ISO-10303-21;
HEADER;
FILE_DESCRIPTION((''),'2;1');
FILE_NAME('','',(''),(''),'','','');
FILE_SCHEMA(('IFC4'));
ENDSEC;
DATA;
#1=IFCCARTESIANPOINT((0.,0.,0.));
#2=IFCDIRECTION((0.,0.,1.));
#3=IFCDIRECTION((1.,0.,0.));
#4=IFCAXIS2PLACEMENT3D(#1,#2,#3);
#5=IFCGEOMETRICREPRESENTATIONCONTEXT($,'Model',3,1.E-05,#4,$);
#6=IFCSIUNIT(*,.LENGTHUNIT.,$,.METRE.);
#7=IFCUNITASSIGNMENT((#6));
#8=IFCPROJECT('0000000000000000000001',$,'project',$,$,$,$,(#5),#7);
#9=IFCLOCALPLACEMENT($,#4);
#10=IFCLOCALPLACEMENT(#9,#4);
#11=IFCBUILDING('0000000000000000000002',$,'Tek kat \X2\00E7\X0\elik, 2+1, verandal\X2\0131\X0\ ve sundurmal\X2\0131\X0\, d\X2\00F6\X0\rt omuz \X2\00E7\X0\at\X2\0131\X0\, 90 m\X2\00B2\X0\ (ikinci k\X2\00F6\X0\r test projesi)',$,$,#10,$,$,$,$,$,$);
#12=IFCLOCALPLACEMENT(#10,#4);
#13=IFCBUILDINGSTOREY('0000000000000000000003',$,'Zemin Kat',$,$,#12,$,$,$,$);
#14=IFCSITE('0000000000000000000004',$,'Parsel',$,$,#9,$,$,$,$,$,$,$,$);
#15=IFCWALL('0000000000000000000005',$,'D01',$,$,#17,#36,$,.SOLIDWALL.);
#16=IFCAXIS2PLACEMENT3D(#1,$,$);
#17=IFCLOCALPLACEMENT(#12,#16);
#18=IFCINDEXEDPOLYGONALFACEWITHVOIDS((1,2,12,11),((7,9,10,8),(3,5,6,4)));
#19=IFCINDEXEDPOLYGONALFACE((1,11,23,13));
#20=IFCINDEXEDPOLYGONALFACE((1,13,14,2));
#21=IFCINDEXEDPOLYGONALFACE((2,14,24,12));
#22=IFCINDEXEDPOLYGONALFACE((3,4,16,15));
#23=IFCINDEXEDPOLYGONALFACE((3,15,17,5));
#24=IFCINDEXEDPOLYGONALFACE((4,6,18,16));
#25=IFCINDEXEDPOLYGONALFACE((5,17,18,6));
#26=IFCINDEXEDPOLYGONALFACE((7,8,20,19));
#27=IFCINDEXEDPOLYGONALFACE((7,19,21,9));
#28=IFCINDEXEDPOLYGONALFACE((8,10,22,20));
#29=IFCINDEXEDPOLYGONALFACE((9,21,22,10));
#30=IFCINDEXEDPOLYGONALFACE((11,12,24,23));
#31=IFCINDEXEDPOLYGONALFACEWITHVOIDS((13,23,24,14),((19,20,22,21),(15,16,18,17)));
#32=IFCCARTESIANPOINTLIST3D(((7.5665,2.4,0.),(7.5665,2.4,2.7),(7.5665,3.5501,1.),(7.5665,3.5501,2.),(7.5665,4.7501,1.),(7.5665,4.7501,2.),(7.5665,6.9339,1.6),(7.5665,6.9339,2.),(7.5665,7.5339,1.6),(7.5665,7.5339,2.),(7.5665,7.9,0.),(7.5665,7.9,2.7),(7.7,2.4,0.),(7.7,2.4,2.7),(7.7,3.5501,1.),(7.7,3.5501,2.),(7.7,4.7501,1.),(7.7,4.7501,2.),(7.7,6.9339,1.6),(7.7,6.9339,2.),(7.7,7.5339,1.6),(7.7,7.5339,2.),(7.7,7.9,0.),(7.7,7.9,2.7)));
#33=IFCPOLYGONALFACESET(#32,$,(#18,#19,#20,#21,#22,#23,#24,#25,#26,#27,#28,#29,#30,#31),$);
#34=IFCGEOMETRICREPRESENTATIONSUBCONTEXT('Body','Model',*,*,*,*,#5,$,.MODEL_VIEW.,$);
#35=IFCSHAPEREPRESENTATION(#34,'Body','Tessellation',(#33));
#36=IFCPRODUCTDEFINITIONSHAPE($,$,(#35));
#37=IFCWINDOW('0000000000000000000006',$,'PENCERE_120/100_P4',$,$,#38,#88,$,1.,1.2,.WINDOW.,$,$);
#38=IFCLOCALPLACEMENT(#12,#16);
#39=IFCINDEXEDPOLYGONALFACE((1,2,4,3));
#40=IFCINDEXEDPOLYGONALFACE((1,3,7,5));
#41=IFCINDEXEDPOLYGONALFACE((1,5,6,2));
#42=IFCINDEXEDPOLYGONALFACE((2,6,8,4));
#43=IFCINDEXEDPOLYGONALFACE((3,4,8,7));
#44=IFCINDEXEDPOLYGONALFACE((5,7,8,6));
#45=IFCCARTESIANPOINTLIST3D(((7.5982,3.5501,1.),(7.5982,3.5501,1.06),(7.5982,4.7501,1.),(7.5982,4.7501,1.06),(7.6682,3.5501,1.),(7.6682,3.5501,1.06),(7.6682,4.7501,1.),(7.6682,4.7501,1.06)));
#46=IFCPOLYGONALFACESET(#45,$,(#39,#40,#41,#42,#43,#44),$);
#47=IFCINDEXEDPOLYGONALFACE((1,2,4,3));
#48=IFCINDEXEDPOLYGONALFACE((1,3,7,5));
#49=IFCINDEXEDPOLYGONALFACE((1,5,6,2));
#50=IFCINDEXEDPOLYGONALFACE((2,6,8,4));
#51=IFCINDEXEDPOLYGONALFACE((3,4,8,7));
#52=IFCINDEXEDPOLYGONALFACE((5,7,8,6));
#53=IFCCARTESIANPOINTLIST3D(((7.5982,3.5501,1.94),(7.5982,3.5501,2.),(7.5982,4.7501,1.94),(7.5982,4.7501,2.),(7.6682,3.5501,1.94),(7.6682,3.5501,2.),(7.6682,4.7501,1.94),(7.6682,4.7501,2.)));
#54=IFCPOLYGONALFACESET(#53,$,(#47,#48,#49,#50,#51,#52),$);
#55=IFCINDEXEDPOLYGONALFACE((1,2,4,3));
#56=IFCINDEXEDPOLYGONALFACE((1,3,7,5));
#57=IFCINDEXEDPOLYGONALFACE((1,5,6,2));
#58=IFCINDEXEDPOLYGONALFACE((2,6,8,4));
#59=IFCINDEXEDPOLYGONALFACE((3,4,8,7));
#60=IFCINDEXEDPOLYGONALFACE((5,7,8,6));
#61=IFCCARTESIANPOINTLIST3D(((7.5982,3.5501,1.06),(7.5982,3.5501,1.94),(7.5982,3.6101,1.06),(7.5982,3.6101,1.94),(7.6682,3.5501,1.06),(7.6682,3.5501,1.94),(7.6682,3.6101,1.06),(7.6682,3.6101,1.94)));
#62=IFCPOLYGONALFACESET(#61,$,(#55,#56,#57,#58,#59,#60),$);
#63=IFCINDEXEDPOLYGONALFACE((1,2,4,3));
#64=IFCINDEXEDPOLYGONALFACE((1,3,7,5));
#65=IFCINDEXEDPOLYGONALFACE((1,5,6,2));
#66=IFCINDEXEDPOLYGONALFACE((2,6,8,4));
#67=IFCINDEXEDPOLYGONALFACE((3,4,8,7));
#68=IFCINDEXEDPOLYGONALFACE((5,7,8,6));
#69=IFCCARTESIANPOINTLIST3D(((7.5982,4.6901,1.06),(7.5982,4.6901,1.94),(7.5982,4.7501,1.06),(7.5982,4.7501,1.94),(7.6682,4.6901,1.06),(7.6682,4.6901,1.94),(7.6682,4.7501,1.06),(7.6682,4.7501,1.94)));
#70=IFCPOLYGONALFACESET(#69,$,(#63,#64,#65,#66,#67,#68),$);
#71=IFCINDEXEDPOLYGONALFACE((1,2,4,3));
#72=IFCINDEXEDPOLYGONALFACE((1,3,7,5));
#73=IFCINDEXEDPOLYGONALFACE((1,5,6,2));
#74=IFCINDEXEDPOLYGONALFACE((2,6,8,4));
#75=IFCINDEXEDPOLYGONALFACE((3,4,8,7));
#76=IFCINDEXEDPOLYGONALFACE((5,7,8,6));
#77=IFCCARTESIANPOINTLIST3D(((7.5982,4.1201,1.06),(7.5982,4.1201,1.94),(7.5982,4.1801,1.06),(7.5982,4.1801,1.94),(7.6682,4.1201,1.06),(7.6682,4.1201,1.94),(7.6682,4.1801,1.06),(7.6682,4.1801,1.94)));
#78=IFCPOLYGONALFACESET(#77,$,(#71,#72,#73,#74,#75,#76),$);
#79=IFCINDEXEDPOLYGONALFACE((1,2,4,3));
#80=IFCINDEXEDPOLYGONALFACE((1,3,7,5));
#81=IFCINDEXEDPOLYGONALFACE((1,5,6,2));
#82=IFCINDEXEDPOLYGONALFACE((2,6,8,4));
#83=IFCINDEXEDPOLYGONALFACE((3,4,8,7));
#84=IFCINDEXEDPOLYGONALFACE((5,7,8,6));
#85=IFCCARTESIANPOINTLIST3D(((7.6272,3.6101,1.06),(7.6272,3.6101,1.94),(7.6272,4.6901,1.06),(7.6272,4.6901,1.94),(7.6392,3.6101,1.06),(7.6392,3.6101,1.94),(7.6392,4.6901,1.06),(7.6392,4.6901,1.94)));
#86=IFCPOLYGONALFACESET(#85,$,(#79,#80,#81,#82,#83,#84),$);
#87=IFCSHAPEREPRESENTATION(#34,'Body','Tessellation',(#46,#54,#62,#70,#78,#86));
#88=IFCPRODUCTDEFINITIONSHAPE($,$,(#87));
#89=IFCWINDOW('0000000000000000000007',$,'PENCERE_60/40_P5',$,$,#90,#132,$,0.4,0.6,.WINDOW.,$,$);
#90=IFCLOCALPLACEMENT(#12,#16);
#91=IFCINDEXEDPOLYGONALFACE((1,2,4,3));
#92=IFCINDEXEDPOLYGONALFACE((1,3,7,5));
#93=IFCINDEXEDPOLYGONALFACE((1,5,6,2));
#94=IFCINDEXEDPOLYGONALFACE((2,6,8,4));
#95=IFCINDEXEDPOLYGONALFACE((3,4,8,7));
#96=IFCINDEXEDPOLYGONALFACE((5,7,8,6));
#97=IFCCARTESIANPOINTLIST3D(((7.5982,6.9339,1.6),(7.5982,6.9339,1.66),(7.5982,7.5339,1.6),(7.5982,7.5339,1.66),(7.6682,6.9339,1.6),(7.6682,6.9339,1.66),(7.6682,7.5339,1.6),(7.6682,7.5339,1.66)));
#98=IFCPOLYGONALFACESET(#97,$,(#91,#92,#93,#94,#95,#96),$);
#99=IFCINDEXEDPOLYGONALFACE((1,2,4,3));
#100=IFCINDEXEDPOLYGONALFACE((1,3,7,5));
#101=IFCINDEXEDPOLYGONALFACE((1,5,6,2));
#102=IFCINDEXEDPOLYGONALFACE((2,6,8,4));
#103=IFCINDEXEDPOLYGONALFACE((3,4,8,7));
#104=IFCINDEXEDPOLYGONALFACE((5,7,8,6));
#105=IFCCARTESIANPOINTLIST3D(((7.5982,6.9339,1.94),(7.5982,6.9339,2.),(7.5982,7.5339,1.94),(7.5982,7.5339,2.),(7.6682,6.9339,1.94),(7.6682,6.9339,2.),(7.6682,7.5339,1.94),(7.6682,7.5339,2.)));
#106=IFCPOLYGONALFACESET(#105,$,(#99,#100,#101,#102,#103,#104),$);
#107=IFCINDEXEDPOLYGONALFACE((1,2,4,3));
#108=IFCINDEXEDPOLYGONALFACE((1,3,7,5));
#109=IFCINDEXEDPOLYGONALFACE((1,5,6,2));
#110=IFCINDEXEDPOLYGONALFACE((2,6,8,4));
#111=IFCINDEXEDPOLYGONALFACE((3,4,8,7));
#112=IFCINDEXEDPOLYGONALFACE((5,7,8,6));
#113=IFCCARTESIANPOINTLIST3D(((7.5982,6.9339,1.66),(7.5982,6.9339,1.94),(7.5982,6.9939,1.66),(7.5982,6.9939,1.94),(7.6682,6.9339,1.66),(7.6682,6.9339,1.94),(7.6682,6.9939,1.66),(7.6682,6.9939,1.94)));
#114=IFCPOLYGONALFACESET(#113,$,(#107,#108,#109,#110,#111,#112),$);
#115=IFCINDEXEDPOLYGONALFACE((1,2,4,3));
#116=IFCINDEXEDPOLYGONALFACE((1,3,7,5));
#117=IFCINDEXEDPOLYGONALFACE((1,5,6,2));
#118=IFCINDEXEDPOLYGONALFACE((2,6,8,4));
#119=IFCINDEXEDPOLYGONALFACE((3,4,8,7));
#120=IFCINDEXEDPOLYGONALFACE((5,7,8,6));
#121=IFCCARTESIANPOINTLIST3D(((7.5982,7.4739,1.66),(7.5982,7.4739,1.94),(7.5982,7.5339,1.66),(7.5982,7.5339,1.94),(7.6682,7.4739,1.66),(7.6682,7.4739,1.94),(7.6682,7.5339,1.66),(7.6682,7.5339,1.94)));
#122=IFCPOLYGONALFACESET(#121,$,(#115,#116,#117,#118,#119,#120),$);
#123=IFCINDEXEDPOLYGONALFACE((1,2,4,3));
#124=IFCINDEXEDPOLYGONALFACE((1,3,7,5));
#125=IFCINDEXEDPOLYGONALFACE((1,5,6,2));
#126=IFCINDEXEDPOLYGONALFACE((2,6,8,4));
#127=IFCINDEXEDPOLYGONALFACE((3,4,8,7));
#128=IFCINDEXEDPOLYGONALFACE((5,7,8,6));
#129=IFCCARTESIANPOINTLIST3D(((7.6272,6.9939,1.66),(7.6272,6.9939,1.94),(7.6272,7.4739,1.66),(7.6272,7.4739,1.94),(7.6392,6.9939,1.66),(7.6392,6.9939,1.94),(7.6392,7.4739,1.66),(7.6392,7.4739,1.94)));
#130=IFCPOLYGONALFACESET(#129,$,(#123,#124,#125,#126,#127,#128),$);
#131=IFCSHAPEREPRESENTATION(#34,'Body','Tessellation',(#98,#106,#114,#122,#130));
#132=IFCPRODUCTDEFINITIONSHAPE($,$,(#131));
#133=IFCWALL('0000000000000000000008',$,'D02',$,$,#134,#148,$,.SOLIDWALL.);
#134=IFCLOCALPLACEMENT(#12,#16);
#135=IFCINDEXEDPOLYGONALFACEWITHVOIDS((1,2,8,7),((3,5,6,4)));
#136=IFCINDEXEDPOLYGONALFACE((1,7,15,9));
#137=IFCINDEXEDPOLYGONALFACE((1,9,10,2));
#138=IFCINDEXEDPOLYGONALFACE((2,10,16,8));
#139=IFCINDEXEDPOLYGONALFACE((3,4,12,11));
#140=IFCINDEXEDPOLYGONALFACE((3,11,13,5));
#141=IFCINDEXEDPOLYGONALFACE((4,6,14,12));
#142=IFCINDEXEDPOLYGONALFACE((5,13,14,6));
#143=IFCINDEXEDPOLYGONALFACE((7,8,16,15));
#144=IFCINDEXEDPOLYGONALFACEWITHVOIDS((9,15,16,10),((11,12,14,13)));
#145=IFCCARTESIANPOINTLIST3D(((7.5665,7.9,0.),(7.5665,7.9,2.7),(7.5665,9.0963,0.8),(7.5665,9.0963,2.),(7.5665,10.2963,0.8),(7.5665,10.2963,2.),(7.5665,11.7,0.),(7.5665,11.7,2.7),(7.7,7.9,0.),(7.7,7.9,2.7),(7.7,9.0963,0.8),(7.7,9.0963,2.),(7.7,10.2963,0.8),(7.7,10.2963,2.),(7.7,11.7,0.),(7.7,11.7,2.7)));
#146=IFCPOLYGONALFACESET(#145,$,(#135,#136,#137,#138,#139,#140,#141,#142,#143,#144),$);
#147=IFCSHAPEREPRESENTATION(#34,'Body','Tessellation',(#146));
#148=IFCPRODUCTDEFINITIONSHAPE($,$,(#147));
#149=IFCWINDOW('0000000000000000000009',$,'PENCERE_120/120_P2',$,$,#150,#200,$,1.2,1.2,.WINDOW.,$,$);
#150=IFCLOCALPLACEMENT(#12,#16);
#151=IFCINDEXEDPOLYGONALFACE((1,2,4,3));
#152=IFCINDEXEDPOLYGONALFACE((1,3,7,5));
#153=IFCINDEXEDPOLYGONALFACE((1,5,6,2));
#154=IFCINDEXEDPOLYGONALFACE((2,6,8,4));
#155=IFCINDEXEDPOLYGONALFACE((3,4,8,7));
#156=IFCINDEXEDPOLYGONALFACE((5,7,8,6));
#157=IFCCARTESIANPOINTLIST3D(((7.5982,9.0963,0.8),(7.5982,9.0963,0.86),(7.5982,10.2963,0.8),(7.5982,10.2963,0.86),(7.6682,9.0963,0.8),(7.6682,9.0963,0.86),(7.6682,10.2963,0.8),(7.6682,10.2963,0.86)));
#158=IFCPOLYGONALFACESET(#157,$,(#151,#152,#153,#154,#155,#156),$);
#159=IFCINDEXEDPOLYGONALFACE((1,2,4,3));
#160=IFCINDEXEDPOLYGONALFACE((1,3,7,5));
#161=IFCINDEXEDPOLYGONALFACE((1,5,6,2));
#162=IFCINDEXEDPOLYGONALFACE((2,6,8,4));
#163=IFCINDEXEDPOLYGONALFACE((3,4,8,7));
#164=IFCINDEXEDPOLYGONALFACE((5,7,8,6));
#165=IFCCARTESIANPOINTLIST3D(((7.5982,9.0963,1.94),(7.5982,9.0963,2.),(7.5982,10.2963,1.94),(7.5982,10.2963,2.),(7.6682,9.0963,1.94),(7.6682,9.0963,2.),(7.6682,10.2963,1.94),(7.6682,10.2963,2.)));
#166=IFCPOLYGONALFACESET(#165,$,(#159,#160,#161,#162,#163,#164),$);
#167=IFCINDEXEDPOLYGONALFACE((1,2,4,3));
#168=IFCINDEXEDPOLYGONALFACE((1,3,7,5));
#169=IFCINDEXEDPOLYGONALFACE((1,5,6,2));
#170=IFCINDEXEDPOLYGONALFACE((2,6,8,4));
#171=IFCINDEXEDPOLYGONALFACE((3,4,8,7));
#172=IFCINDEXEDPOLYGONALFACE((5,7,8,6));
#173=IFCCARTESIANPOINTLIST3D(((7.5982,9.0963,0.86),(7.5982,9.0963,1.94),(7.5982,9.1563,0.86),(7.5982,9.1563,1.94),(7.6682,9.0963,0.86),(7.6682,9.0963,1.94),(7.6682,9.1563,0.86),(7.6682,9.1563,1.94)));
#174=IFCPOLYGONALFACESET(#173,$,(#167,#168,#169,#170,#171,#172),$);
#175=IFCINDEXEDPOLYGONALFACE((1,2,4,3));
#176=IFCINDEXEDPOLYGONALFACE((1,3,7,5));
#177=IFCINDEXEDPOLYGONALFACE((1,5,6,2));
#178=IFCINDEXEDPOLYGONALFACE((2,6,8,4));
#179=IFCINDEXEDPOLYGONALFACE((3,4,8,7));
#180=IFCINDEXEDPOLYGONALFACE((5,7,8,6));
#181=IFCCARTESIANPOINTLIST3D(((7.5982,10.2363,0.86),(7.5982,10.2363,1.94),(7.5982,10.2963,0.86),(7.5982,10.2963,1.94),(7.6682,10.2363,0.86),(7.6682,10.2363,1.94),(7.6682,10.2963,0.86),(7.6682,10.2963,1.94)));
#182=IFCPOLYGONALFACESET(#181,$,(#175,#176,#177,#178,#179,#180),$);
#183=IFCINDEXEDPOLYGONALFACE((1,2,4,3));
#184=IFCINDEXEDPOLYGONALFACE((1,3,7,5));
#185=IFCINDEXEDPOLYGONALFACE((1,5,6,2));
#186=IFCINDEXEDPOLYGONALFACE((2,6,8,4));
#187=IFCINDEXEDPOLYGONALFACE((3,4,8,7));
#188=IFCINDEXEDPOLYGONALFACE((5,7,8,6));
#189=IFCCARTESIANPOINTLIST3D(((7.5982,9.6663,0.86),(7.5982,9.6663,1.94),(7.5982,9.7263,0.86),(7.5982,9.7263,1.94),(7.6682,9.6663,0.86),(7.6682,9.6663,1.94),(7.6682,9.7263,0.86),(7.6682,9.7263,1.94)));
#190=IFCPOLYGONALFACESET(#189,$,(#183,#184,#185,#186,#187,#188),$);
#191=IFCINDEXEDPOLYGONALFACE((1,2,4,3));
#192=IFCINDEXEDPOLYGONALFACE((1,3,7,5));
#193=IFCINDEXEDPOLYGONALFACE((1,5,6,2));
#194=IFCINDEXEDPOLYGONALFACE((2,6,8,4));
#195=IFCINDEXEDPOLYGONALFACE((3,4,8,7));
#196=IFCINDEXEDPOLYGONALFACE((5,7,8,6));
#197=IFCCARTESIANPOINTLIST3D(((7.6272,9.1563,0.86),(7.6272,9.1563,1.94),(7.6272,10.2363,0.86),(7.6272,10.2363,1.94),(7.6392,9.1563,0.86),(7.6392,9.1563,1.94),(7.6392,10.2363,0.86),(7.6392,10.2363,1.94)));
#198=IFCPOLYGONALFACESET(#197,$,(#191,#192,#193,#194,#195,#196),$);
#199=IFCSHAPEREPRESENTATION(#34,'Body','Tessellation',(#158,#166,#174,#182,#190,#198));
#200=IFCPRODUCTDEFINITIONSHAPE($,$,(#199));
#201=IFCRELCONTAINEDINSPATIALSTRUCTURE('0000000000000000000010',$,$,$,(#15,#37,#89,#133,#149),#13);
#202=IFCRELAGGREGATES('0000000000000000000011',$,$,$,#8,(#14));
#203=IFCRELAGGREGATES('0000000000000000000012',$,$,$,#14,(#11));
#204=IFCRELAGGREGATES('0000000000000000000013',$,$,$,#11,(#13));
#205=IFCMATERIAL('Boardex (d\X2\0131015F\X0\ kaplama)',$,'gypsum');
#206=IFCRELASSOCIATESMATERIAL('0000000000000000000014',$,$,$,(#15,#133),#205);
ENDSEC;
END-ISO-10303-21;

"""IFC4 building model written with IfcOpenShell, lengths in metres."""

from ifc_helpers import new_model, si_unit, frame, origin_with_axes, place, context, subcontext, project, spatial, line, indexed_curve, outline, extrude, material, element, fill, save


model = new_model("IFC4")

# Units and contexts
model_context = context("Model", 3, precision=1e-05, world=origin_with_axes())
body_context = subcontext(model_context, "Body", "Model", "MODEL_VIEW")
ifc_project = project(units=[si_unit("LENGTHUNIT", "METRE")], contexts=[model_context])

# Site, building, storey
site_placement = place(None, origin_with_axes())
site = spatial("IfcSite", under=ifc_project, at=site_placement, Name="Parsel")
building_placement = place(site_placement, origin_with_axes())
building = spatial("IfcBuilding", under=site, at=building_placement, Name="Tek kat çelik, 2+1, verandalı ve sundurmalı, dört omuz çatı, 90 m² (ikinci kör test projesi)")
storey_placement = place(building_placement, origin_with_axes())
storey = spatial("IfcBuildingStorey", under=building, at=storey_placement, Name="Zemin Kat")

# Wall, openings, windows
ifc_material_1 = material(Name="Boardex (dış kaplama)", Category="gypsum")
wall_1_placement = place(storey_placement, origin_with_axes())
wall_1 = element("IfcWall", 1, at=wall_1_placement, inside=storey, material=ifc_material_1, Name="D01", PredefinedType="SOLIDWALL", context=body_context, shape_type="SweptSolid", body=[
    extrude(outline(indexed_curve([(0.0, 0.0), (0.1335, 0.0), (0.1335, 5.5), (0.0, 5.5)], segments=[line(1, 2, 3, 4, 1)])), frame((7.5665, 2.4, 0.0), z_axis=(0.0, 0.0, 1.0), x_axis=(1.0, 0.0, 0.0)), (0.0, 0.0, 1.0), 2.7),
])
opening_1_placement = place(wall_1_placement, origin_with_axes())
opening_1 = element("IfcOpeningElement", 2, at=opening_1_placement, cuts=wall_1, PredefinedType="OPENING", context=body_context, shape_type="SweptSolid", body=[
    extrude(outline(indexed_curve([(0.0, 0.0), (0.1735, 0.0), (0.1735, 1.2), (0.0, 1.2)], segments=[line(1, 2, 3, 4, 1)])), frame((7.5465, 3.5501, 1.0), z_axis=(0.0, 0.0, 1.0), x_axis=(1.0, 0.0, 0.0)), (0.0, 0.0, 1.0), 1.0),
])
opening_2_placement = place(wall_1_placement, origin_with_axes())
opening_2 = element("IfcOpeningElement", 3, at=opening_2_placement, cuts=wall_1, PredefinedType="OPENING", context=body_context, shape_type="SweptSolid", body=[
    extrude(outline(indexed_curve([(0.0, 0.0), (0.1735, 0.0), (0.1735, 0.6), (0.0, 0.6)], segments=[line(1, 2, 3, 4, 1)])), frame((7.5465, 6.9339, 1.6), z_axis=(0.0, 0.0, 1.0), x_axis=(1.0, 0.0, 0.0)), (0.0, 0.0, 1.0), 0.4),
])
window_1_placement = place(storey_placement, origin_with_axes())
window_1 = element("IfcWindow", 4, at=window_1_placement, inside=storey, Name="PENCERE_120/100_P4", OverallHeight=1.0, OverallWidth=1.2, PredefinedType="WINDOW", context=body_context, shape_type="SweptSolid", body=[
    extrude(outline(indexed_curve([(0.0, 0.0), (0.07, 0.0), (0.07, 1.2), (0.0, 1.2)], segments=[line(1, 2, 3, 4, 1)])), frame((7.5983, 3.5501, 1.0), z_axis=(0.0, 0.0, 1.0), x_axis=(1.0, 0.0, 0.0)), (0.0, 0.0, 1.0), 0.06),
    extrude(outline(indexed_curve([(0.0, 0.0), (0.07, 0.0), (0.07, 1.2), (0.0, 1.2)], segments=[line(1, 2, 3, 4, 1)])), frame((7.5983, 3.5501, 1.94), z_axis=(0.0, 0.0, 1.0), x_axis=(1.0, 0.0, 0.0)), (0.0, 0.0, 1.0), 0.06),
    extrude(outline(indexed_curve([(0.0, 0.0), (0.07, 0.0), (0.07, 0.06), (0.0, 0.06)], segments=[line(1, 2, 3, 4, 1)])), frame((7.5983, 3.5501, 1.06), z_axis=(0.0, 0.0, 1.0), x_axis=(1.0, 0.0, 0.0)), (0.0, 0.0, 1.0), 0.88),
    extrude(outline(indexed_curve([(0.0, 0.0), (0.07, 0.0), (0.07, 0.06), (0.0, 0.06)], segments=[line(1, 2, 3, 4, 1)])), frame((7.5983, 4.6901, 1.06), z_axis=(0.0, 0.0, 1.0), x_axis=(1.0, 0.0, 0.0)), (0.0, 0.0, 1.0), 0.88),
    extrude(outline(indexed_curve([(0.0, 0.0), (0.07, 0.0), (0.07, 0.06), (0.0, 0.06)], segments=[line(1, 2, 3, 4, 1)])), frame((7.5983, 4.1201, 1.06), z_axis=(0.0, 0.0, 1.0), x_axis=(1.0, 0.0, 0.0)), (0.0, 0.0, 1.0), 0.88),
    extrude(outline(indexed_curve([(0.0, 0.0), (0.012, 0.0), (0.012, 1.08), (0.0, 1.08)], segments=[line(1, 2, 3, 4, 1)])), frame((7.6273, 3.6101, 1.06), z_axis=(0.0, 0.0, 1.0), x_axis=(1.0, 0.0, 0.0)), (0.0, 0.0, 1.0), 0.88),
])
fill(opening_1, window_1)
window_2_placement = place(storey_placement, origin_with_axes())
window_2 = element("IfcWindow", 5, at=window_2_placement, inside=storey, Name="PENCERE_60/40_P5", OverallHeight=0.4, OverallWidth=0.6, PredefinedType="WINDOW", context=body_context, shape_type="SweptSolid", body=[
    extrude(outline(indexed_curve([(0.0, 0.0), (0.07, 0.0), (0.07, 0.6), (0.0, 0.6)], segments=[line(1, 2, 3, 4, 1)])), frame((7.5983, 6.9339, 1.6), z_axis=(0.0, 0.0, 1.0), x_axis=(1.0, 0.0, 0.0)), (0.0, 0.0, 1.0), 0.06),
    extrude(outline(indexed_curve([(0.0, 0.0), (0.07, 0.0), (0.07, 0.6), (0.0, 0.6)], segments=[line(1, 2, 3, 4, 1)])), frame((7.5983, 6.9339, 1.94), z_axis=(0.0, 0.0, 1.0), x_axis=(1.0, 0.0, 0.0)), (0.0, 0.0, 1.0), 0.06),
    extrude(outline(indexed_curve([(0.0, 0.0), (0.07, 0.0), (0.07, 0.06), (0.0, 0.06)], segments=[line(1, 2, 3, 4, 1)])), frame((7.5983, 6.9339, 1.66), z_axis=(0.0, 0.0, 1.0), x_axis=(1.0, 0.0, 0.0)), (0.0, 0.0, 1.0), 0.28),
    extrude(outline(indexed_curve([(0.0, 0.0), (0.07, 0.0), (0.07, 0.06), (0.0, 0.06)], segments=[line(1, 2, 3, 4, 1)])), frame((7.5983, 7.4739, 1.66), z_axis=(0.0, 0.0, 1.0), x_axis=(1.0, 0.0, 0.0)), (0.0, 0.0, 1.0), 0.28),
    extrude(outline(indexed_curve([(0.0, 0.0), (0.012, 0.0), (0.012, 0.48), (0.0, 0.48)], segments=[line(1, 2, 3, 4, 1)])), frame((7.6273, 6.9939, 1.66), z_axis=(0.0, 0.0, 1.0), x_axis=(1.0, 0.0, 0.0)), (0.0, 0.0, 1.0), 0.28),
])
fill(opening_2, window_2)

# Wall, opening, window
wall_2_placement = place(storey_placement, origin_with_axes())
wall_2 = element("IfcWall", 6, at=wall_2_placement, inside=storey, material=ifc_material_1, Name="D02", PredefinedType="SOLIDWALL", context=body_context, shape_type="SweptSolid", body=[
    extrude(outline(indexed_curve([(0.0, 0.0), (0.1335, 0.0), (0.1335, 3.8), (0.0, 3.8)], segments=[line(1, 2, 3, 4, 1)])), frame((7.5665, 7.9, 0.0), z_axis=(0.0, 0.0, 1.0), x_axis=(1.0, 0.0, 0.0)), (0.0, 0.0, 1.0), 2.7),
])
opening_3_placement = place(wall_2_placement, origin_with_axes())
opening_3 = element("IfcOpeningElement", 7, at=opening_3_placement, cuts=wall_2, PredefinedType="OPENING", context=body_context, shape_type="SweptSolid", body=[
    extrude(outline(indexed_curve([(0.0, 0.0), (0.1735, 0.0), (0.1735, 1.2), (0.0, 1.2)], segments=[line(1, 2, 3, 4, 1)])), frame((7.5465, 9.0963, 0.8), z_axis=(0.0, 0.0, 1.0), x_axis=(1.0, 0.0, 0.0)), (0.0, 0.0, 1.0), 1.2),
])
window_3_placement = place(storey_placement, origin_with_axes())
window_3 = element("IfcWindow", 8, at=window_3_placement, inside=storey, Name="PENCERE_120/120_P2", OverallHeight=1.2, OverallWidth=1.2, PredefinedType="WINDOW", context=body_context, shape_type="SweptSolid", body=[
    extrude(outline(indexed_curve([(0.0, 0.0), (0.07, 0.0), (0.07, 1.2), (0.0, 1.2)], segments=[line(1, 2, 3, 4, 1)])), frame((7.5983, 9.0963, 0.8), z_axis=(0.0, 0.0, 1.0), x_axis=(1.0, 0.0, 0.0)), (0.0, 0.0, 1.0), 0.06),
    extrude(outline(indexed_curve([(0.0, 0.0), (0.07, 0.0), (0.07, 1.2), (0.0, 1.2)], segments=[line(1, 2, 3, 4, 1)])), frame((7.5983, 9.0963, 1.94), z_axis=(0.0, 0.0, 1.0), x_axis=(1.0, 0.0, 0.0)), (0.0, 0.0, 1.0), 0.06),
    extrude(outline(indexed_curve([(0.0, 0.0), (0.07, 0.0), (0.07, 0.06), (0.0, 0.06)], segments=[line(1, 2, 3, 4, 1)])), frame((7.5983, 9.0963, 0.86), z_axis=(0.0, 0.0, 1.0), x_axis=(1.0, 0.0, 0.0)), (0.0, 0.0, 1.0), 1.08),
    extrude(outline(indexed_curve([(0.0, 0.0), (0.07, 0.0), (0.07, 0.06), (0.0, 0.06)], segments=[line(1, 2, 3, 4, 1)])), frame((7.5983, 10.2363, 0.86), z_axis=(0.0, 0.0, 1.0), x_axis=(1.0, 0.0, 0.0)), (0.0, 0.0, 1.0), 1.08),
    extrude(outline(indexed_curve([(0.0, 0.0), (0.07, 0.0), (0.07, 0.06), (0.0, 0.06)], segments=[line(1, 2, 3, 4, 1)])), frame((7.5983, 9.6663, 0.86), z_axis=(0.0, 0.0, 1.0), x_axis=(1.0, 0.0, 0.0)), (0.0, 0.0, 1.0), 1.08),
    extrude(outline(indexed_curve([(0.0, 0.0), (0.012, 0.0), (0.012, 1.08), (0.0, 1.08)], segments=[line(1, 2, 3, 4, 1)])), frame((7.6273, 9.1563, 0.86), z_axis=(0.0, 0.0, 1.0), x_axis=(1.0, 0.0, 0.0)), (0.0, 0.0, 1.0), 1.08),
])
fill(opening_3, window_3)

save(model, "model.ifc")
